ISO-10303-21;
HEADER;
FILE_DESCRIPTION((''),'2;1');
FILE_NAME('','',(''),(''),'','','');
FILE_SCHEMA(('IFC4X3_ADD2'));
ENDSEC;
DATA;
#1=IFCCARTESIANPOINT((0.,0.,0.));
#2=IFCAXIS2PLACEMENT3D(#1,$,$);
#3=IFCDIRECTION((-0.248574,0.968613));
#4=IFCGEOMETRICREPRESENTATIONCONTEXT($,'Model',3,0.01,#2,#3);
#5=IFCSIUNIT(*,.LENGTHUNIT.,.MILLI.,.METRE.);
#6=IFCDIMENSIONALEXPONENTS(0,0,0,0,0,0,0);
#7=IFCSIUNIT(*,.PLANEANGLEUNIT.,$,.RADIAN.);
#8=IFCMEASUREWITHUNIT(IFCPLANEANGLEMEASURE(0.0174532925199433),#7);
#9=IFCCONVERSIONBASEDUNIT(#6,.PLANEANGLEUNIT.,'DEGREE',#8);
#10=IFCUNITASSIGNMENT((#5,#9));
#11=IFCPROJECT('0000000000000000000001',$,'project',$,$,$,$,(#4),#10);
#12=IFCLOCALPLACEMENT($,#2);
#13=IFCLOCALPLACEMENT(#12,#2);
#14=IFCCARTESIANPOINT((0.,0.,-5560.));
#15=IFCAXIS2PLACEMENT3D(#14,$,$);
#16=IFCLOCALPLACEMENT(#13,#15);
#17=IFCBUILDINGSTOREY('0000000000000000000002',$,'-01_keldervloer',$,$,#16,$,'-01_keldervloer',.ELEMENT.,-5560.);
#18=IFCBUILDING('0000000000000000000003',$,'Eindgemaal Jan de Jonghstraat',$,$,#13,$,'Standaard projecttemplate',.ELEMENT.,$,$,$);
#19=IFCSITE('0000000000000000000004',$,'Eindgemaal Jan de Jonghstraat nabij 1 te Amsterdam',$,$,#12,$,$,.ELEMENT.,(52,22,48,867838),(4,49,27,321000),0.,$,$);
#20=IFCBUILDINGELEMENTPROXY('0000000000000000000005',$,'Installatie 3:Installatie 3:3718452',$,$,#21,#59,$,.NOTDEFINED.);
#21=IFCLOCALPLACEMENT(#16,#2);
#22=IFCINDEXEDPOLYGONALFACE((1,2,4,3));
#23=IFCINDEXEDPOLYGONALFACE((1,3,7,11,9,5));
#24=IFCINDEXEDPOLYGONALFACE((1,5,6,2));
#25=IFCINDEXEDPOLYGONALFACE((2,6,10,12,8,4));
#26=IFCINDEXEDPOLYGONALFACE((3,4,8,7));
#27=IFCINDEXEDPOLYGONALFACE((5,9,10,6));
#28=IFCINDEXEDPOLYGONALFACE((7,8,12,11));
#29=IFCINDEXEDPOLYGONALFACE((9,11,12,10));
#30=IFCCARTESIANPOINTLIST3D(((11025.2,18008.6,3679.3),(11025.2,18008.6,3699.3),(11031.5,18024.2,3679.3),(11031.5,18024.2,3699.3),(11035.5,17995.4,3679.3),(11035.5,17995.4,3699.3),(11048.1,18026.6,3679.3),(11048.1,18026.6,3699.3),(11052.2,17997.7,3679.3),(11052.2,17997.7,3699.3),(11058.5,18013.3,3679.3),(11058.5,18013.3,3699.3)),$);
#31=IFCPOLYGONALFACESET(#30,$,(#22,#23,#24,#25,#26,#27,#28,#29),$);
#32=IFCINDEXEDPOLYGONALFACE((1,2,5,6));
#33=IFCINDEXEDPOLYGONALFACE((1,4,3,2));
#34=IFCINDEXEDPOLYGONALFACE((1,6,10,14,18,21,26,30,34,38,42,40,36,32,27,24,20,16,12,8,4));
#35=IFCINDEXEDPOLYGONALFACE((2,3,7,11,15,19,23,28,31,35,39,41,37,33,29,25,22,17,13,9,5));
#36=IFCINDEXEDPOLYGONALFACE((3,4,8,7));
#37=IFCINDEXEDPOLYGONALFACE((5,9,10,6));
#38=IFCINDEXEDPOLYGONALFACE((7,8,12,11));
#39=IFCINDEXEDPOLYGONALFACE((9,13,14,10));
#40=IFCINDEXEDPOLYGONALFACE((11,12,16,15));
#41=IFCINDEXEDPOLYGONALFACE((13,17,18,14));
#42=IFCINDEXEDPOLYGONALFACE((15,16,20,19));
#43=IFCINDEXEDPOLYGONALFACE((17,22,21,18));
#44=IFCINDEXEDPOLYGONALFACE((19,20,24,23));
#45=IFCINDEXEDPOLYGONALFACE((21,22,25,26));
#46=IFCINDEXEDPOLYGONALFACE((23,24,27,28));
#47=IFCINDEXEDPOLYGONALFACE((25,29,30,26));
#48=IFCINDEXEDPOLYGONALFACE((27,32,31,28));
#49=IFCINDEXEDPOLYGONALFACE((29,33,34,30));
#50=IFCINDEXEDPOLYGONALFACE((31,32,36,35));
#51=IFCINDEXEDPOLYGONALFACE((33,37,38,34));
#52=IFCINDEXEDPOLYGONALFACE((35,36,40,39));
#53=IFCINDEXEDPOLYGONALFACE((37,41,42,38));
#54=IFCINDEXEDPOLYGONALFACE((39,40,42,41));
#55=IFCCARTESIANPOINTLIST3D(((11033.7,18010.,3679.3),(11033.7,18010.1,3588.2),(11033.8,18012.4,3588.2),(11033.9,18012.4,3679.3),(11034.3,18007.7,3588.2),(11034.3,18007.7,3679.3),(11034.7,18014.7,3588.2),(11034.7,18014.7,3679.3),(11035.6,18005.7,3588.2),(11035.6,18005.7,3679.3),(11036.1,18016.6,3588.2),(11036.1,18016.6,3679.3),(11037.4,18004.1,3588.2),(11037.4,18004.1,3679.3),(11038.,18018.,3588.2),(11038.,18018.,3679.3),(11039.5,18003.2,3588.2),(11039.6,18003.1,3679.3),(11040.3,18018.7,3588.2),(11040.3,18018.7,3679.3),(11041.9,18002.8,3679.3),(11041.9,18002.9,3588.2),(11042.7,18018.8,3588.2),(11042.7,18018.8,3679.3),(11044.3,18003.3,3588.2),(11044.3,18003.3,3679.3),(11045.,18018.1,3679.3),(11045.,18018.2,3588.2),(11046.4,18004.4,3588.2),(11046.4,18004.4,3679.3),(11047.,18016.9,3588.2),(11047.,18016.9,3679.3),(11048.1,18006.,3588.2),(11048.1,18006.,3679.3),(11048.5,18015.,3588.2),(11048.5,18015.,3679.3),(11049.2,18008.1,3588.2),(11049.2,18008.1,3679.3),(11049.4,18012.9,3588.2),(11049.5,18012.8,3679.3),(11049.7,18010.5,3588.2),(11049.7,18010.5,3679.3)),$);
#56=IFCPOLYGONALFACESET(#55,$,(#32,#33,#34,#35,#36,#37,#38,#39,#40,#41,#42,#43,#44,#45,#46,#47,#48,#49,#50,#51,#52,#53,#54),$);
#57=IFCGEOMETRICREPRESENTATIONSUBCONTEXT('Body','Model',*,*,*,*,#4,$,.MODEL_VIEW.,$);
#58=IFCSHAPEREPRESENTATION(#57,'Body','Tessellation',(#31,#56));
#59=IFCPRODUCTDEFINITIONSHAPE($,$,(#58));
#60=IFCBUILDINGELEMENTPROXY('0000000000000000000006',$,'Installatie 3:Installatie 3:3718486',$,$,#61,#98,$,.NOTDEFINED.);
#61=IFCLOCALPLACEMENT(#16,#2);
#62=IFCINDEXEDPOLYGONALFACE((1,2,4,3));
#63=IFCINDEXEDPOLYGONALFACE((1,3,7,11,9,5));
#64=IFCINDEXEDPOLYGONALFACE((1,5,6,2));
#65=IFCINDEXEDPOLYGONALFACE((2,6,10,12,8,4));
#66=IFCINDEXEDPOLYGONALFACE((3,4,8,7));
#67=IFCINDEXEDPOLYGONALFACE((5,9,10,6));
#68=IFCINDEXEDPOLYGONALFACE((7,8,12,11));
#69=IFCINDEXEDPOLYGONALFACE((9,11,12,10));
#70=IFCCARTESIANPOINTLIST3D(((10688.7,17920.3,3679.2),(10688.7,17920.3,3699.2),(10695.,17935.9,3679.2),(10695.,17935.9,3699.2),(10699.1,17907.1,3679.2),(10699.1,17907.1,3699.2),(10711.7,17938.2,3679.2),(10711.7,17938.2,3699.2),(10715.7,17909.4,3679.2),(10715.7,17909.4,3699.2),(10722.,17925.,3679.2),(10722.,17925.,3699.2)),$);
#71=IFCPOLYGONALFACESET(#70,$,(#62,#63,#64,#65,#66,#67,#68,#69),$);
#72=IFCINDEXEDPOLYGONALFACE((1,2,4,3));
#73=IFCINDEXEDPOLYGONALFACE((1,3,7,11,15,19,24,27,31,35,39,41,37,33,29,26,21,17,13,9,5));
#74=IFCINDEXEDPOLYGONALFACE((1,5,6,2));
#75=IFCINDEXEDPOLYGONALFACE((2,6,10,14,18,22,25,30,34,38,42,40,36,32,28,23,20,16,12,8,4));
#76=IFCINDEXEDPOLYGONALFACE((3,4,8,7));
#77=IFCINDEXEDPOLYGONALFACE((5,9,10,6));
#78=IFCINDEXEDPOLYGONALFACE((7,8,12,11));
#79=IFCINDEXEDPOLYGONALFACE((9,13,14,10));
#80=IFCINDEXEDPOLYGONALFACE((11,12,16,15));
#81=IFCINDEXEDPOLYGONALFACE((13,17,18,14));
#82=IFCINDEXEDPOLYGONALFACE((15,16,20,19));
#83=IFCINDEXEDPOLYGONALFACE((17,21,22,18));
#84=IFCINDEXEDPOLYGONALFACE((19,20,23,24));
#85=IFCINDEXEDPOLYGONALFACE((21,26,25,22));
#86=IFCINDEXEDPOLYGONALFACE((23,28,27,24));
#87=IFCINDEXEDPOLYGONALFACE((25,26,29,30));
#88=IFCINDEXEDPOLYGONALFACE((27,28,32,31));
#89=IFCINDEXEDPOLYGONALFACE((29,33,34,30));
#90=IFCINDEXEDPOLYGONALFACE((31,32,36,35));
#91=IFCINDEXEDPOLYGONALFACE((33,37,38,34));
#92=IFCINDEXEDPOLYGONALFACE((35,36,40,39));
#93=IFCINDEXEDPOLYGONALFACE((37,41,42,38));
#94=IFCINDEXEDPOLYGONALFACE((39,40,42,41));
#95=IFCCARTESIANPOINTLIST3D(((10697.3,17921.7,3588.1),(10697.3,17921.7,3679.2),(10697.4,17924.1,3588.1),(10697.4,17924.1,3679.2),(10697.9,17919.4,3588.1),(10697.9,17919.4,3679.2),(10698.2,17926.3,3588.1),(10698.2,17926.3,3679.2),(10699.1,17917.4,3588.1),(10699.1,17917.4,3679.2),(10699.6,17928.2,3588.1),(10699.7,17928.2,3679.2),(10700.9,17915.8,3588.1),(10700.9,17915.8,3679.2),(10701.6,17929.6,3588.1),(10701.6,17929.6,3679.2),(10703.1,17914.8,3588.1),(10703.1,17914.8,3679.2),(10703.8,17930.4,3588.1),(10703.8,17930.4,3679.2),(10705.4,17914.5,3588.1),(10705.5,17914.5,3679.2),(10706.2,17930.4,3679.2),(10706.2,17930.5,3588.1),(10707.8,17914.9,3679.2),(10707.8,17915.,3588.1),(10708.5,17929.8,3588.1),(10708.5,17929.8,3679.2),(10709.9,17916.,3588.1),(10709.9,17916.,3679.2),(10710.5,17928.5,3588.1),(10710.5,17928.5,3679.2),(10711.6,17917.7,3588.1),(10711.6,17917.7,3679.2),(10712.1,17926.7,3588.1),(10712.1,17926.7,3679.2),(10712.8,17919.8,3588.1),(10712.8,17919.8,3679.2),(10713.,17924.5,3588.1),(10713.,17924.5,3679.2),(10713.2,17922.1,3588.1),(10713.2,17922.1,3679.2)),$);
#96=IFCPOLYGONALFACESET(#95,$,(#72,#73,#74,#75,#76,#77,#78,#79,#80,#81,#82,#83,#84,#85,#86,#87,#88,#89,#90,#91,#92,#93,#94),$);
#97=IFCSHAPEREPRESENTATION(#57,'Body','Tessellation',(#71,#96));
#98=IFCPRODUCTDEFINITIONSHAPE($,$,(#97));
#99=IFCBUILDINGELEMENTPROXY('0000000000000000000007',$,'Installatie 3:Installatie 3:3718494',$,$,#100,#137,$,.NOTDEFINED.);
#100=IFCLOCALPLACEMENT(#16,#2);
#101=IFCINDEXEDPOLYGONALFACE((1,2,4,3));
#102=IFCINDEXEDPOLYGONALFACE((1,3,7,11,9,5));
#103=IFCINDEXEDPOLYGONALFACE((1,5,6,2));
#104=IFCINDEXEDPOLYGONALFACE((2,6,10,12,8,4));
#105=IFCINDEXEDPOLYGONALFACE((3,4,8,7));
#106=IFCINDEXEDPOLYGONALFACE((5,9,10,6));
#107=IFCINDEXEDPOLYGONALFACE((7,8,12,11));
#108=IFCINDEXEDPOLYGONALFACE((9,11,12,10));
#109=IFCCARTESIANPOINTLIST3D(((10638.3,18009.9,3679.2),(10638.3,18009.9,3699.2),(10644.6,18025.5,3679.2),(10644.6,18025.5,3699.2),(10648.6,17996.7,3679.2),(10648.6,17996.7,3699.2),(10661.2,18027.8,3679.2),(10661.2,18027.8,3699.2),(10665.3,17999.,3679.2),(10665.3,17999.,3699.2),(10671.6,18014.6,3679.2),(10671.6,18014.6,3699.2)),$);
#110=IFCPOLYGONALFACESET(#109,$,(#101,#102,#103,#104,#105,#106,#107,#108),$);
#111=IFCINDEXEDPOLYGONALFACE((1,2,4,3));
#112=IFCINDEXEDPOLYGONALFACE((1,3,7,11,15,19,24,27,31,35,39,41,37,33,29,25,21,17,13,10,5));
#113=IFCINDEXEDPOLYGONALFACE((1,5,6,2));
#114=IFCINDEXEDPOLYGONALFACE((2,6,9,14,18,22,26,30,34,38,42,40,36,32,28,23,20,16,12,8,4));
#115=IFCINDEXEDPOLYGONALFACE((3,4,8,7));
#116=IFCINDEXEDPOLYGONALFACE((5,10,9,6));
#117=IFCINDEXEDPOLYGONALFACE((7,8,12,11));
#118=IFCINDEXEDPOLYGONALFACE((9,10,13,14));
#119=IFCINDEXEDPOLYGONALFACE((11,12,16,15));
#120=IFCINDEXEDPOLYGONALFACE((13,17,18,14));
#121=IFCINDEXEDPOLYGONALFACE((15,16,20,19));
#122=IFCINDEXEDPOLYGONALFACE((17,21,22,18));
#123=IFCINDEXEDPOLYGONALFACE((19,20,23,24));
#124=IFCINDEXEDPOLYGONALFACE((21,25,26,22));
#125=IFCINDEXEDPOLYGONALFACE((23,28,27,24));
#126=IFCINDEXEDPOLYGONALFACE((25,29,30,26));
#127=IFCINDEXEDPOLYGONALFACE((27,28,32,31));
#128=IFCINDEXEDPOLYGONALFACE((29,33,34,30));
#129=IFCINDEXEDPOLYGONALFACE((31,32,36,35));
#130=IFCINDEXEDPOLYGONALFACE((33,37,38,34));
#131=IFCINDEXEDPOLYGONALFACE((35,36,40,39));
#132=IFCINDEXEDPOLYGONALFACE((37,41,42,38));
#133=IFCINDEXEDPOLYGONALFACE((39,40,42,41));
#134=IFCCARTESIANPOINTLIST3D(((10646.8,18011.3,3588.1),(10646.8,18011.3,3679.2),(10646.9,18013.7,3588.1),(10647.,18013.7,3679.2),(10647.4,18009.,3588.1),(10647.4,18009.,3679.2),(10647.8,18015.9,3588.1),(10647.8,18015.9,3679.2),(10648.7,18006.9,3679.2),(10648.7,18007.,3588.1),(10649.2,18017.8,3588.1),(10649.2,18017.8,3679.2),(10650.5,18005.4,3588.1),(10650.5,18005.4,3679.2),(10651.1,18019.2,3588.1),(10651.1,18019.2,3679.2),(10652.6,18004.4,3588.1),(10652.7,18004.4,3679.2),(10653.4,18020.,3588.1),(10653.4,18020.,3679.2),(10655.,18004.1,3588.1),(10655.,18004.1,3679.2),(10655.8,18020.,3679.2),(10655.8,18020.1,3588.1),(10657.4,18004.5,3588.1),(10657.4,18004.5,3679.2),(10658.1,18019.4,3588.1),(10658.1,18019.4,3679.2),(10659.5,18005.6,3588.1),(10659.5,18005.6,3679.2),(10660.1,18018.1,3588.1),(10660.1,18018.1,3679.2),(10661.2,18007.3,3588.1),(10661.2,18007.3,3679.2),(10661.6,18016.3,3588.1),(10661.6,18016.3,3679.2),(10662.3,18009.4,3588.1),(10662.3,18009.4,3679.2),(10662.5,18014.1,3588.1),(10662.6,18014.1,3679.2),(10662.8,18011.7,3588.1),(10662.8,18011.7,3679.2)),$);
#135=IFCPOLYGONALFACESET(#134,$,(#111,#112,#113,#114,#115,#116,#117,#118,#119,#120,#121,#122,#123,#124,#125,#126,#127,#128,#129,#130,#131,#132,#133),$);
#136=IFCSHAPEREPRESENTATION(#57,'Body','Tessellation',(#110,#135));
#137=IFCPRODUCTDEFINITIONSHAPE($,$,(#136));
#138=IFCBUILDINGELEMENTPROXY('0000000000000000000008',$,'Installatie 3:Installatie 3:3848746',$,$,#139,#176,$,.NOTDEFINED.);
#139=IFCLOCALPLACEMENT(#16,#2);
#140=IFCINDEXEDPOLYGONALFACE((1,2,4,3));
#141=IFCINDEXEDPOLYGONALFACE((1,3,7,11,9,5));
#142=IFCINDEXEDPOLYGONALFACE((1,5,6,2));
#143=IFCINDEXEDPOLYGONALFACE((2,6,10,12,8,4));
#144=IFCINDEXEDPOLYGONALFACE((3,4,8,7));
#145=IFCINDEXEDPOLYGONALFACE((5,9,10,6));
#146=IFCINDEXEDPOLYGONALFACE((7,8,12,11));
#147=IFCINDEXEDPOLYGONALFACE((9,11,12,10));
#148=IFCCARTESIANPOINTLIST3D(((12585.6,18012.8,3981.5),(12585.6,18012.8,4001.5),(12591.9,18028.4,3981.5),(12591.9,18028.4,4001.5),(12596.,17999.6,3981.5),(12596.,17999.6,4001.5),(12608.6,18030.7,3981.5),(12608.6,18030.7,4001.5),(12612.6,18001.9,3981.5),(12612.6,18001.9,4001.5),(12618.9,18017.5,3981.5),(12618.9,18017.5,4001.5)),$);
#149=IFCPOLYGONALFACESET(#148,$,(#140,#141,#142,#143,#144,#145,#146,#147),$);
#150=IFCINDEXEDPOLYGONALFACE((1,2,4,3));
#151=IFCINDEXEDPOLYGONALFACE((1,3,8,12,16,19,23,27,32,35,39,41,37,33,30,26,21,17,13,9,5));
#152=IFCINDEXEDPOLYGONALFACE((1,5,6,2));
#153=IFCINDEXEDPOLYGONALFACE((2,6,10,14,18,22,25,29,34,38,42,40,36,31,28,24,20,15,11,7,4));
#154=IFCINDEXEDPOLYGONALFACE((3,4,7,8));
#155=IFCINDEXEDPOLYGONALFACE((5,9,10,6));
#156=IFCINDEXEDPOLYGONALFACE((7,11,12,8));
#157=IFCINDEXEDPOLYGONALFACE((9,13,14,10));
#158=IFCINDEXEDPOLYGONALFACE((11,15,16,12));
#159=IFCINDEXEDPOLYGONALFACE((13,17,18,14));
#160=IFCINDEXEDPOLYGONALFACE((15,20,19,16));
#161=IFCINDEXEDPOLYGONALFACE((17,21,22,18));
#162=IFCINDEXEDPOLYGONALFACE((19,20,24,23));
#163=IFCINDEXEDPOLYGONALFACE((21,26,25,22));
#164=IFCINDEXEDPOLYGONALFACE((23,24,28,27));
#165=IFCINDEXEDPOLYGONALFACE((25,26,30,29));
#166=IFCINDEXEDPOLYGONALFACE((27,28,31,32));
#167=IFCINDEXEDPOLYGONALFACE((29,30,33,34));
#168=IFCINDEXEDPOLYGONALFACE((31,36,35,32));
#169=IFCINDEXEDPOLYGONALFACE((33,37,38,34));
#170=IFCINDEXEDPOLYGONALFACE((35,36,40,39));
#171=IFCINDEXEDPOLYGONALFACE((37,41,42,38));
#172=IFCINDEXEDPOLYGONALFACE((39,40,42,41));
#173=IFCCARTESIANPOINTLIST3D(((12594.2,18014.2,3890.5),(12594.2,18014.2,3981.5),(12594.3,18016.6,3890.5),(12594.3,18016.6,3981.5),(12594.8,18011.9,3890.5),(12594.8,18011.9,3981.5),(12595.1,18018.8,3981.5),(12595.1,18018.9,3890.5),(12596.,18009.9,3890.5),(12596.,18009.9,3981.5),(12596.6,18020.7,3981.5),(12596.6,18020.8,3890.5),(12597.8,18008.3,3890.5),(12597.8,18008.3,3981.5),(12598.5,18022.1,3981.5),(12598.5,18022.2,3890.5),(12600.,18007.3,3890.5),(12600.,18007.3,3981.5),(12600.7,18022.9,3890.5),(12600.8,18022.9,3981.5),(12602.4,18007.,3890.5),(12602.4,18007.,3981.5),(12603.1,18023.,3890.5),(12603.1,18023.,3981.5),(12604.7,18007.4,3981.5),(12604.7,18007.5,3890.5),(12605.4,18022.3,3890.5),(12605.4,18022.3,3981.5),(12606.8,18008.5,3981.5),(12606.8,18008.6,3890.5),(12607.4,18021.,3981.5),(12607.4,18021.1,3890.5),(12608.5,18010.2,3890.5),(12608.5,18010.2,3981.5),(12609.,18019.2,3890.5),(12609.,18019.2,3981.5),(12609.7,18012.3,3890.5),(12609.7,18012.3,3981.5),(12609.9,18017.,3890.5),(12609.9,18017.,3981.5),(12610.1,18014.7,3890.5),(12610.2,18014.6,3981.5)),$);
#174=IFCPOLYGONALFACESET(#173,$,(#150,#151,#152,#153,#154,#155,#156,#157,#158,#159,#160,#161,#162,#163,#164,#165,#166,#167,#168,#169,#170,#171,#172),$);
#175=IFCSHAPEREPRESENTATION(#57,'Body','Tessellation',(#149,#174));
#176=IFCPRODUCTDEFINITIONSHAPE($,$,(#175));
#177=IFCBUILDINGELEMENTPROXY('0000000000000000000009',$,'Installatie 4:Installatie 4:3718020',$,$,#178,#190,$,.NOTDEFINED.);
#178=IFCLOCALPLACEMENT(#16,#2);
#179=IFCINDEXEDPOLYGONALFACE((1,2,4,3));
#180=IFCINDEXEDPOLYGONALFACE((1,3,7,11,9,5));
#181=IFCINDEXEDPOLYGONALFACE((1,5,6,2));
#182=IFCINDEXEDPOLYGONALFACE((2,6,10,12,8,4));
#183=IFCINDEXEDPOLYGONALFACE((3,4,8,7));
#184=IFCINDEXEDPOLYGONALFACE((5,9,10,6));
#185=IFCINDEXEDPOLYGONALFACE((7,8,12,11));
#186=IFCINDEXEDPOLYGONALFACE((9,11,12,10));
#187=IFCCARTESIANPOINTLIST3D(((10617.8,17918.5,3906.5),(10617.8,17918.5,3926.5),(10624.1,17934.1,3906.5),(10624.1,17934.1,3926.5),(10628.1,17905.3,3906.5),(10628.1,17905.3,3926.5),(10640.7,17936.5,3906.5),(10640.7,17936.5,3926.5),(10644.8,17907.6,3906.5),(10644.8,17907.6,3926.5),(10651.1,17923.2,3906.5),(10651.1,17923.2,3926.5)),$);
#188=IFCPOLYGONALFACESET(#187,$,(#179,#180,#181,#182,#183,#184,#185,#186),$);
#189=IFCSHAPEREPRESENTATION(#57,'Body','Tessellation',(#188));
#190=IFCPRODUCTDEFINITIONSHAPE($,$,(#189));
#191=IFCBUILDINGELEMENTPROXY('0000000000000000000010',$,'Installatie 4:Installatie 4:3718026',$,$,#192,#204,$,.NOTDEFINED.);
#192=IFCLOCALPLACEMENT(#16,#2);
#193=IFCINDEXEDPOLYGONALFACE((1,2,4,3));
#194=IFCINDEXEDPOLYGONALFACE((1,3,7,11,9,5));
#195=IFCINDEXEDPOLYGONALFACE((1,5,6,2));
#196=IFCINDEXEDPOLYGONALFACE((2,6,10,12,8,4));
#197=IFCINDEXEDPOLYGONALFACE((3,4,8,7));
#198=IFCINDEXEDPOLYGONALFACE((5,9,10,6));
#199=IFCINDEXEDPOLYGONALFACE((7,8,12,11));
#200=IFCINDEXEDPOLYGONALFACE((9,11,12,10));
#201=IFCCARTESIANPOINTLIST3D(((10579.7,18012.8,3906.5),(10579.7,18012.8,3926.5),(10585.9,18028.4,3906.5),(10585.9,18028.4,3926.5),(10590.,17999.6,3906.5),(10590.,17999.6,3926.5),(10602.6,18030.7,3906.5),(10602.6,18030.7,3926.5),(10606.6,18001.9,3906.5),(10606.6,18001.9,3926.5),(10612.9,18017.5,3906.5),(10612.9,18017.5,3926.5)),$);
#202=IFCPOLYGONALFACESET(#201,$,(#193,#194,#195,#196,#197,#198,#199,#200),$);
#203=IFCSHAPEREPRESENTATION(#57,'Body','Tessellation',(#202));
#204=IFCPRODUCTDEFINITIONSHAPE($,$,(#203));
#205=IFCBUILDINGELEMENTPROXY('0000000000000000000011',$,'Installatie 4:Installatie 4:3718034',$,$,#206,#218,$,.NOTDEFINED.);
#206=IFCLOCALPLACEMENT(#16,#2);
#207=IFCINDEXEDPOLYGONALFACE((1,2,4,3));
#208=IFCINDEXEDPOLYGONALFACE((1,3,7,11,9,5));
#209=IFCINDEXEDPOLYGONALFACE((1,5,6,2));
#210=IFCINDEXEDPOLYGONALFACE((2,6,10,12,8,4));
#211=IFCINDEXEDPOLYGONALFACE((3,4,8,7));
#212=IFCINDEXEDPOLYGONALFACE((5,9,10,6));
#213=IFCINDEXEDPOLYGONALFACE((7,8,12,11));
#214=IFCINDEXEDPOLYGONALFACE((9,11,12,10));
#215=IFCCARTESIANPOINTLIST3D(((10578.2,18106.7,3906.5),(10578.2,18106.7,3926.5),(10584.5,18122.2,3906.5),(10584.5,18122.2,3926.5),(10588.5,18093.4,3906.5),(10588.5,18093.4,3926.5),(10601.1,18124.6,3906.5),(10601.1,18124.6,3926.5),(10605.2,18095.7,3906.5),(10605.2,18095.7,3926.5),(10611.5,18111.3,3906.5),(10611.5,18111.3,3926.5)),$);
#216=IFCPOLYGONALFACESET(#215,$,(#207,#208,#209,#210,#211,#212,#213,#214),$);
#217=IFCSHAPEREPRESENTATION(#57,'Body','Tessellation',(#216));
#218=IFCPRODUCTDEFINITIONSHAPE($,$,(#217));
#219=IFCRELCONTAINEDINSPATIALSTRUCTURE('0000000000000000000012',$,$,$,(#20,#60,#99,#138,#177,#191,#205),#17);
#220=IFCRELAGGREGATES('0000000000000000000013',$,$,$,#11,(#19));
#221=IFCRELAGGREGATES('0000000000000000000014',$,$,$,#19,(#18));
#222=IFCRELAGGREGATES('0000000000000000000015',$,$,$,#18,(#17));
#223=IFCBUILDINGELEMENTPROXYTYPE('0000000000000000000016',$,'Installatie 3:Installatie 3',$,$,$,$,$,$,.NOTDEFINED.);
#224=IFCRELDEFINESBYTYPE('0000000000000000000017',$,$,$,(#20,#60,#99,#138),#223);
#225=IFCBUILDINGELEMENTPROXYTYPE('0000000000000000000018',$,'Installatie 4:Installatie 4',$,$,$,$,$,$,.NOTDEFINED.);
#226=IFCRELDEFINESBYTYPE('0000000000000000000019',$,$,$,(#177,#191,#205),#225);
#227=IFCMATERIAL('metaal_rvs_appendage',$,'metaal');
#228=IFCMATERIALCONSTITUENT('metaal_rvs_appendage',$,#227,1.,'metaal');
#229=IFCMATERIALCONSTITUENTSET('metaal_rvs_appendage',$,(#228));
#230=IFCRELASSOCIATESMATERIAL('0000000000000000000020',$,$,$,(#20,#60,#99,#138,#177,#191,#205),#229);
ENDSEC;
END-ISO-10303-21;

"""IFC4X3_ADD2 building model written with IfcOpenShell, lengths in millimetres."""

from ifc_helpers import new_model, entity, si_unit, converted_unit, direction, frame, frame_2d, origin, place, context, subcontext, project, spatial, polyline, circle, outline, extrude, source, transform, mapped, material, constituent, constituent_set, type_object, type_shapes, element, save


model = new_model("IFC4X3_ADD2")

# Units and contexts
model_context = context("Model", 3, precision=0.01, world=origin(), true_north=direction((-0.248574, 0.968613)))
body_context = subcontext(model_context, "Body", "Model", "MODEL_VIEW")
ifc_project = project(units=[si_unit("LENGTHUNIT", "METRE", prefix="MILLI"), converted_unit("PLANEANGLEUNIT", "DEGREE", entity("IfcPlaneAngleMeasure", 0.0174532925199433), si_unit("PLANEANGLEUNIT", "RADIAN"), dimensions=[0, 0, 0, 0, 0, 0, 0])], contexts=[model_context])

# Site, building, storey
site_placement = place(None, origin())
site = spatial("IfcSite", under=ifc_project, at=site_placement, Name="Eindgemaal Jan de Jonghstraat nabij 1 te Amsterdam", CompositionType="ELEMENT", RefLatitude=(52, 22, 48, 867838), RefLongitude=(4, 49, 27, 321000), RefElevation=0.0)
building_placement = place(site_placement, origin())
building = spatial("IfcBuilding", under=site, at=building_placement, Name="Eindgemaal Jan de Jonghstraat", LongName="Standaard projecttemplate", CompositionType="ELEMENT")
storey_placement = place(building_placement, frame((0.0, 0.0, -5560.0)))
storey = spatial("IfcBuildingStorey", under=building, at=storey_placement, Name="-01_keldervloer", LongName="-01_keldervloer", CompositionType="ELEMENT", Elevation=-5560.0)

# Building element proxies
ifc_material_1 = material(Name="metaal_rvs_appendage", Category="metaal")
ifc_constituent_1 = constituent(ifc_material_1, Name="metaal_rvs_appendage", Category="metaal", fraction=1.0)
ifc_constituent_set_1 = constituent_set(constituents=[ifc_constituent_1], Name="metaal_rvs_appendage")
building_element_proxy_type_1 = type_object("IfcBuildingElementProxyType", Name="Installatie 3:Installatie 3", PredefinedType="NOTDEFINED")
shared_shape_1 = source(origin(), body_context, "Body", "SweptSolid", [
    extrude(outline(polyline([(-8.4, -14.6), (8.4, -14.6), (16.8, 0.0), (8.4, 14.6), (-8.4, 14.6), (-16.8, 0.0), (-8.4, -14.6)])), frame((0.0, 0.0, 41.5), z_axis=(0.0, 0.0, 1.0), x_axis=(-0.400458, 0.916315, 0.0)), (0.0, 0.0, 1.0), 20.0),
    extrude(circle(Radius=8.0, at=frame_2d((0.0, 0.0), x_axis=(1.0, 0.0))), frame((-0.2, -0.1, -49.5), z_axis=(0.000101, -0.000286, 1.0), x_axis=(1.0, 0.0, -0.000101)), (0.0, 0.0, 1.0), 91.1),
])
type_shapes(building_element_proxy_type_1, [shared_shape_1])
for number, where, z_axis, x_axis, name in (
    (1, (11041.8, 18011.0, 3637.8), (0.0, 0.0, 1.0), (0.968613, 0.248574, 0.0), "Installatie 3:Installatie 3:3718452"),
    (2, (10705.4, 17922.7, 3637.7), (0.0, 0.0, 1.0), (0.968613, 0.248574, 0.0), "Installatie 3:Installatie 3:3718486"),
    (3, (10654.9, 18012.2, 3637.7), (0.0, 0.0, 1.0), (0.968613, 0.248574, 0.0), "Installatie 3:Installatie 3:3718494"),
    (4, (12602.3, 18015.2, 3940.0), (0.0, 0.0, 1.0), (0.968613, 0.248574, 0.0), "Installatie 3:Installatie 3:3848746"),
):
    element("IfcBuildingElementProxy", number, at=place(storey_placement, frame(where, z_axis=z_axis, x_axis=x_axis)), inside=storey, type_object=building_element_proxy_type_1, material=ifc_constituent_set_1, Name=name, PredefinedType="NOTDEFINED", context=body_context, shape_type="MappedRepresentation", body=[
        mapped(shared_shape_1, transform((0.0, 0.0, 0.0), scale=1.0)),
    ])
building_element_proxy_type_2 = type_object("IfcBuildingElementProxyType", Name="Installatie 4:Installatie 4", PredefinedType="NOTDEFINED")
shared_shape_2 = source(origin(), body_context, "Body", "SweptSolid", [
    extrude(outline(polyline([(-8.4, -14.6), (8.4, -14.6), (16.8, 0.0), (8.4, 14.6), (-8.4, 14.6), (-16.8, 0.0), (-8.4, -14.6)])), frame((0.0, 0.0, -11.0), z_axis=(0.0, 0.0, 1.0), x_axis=(0.400458, -0.916315, 0.0)), (0.0, 0.0, 1.0), 20.0),
])
type_shapes(building_element_proxy_type_2, [shared_shape_2])
for number, where, z_axis, x_axis, name in (
    (5, (10634.4, 17920.9, 3917.5), (0.0, 0.0, 1.0), (0.968613, 0.248574, 0.0), "Installatie 4:Installatie 4:3718020"),
    (6, (10596.3, 18015.2, 3917.5), (0.0, 0.0, 1.0), (0.968613, 0.248574, 0.0), "Installatie 4:Installatie 4:3718026"),
    (7, (10594.8, 18109.0, 3917.5), (0.0, 0.0, 1.0), (0.968613, 0.248574, 0.0), "Installatie 4:Installatie 4:3718034"),
):
    element("IfcBuildingElementProxy", number, at=place(storey_placement, frame(where, z_axis=z_axis, x_axis=x_axis)), inside=storey, type_object=building_element_proxy_type_2, material=ifc_constituent_set_1, Name=name, PredefinedType="NOTDEFINED", context=body_context, shape_type="MappedRepresentation", body=[
        mapped(shared_shape_2, transform((0.0, 0.0, 0.0), scale=1.0)),
    ])

save(model, "model.ifc")
